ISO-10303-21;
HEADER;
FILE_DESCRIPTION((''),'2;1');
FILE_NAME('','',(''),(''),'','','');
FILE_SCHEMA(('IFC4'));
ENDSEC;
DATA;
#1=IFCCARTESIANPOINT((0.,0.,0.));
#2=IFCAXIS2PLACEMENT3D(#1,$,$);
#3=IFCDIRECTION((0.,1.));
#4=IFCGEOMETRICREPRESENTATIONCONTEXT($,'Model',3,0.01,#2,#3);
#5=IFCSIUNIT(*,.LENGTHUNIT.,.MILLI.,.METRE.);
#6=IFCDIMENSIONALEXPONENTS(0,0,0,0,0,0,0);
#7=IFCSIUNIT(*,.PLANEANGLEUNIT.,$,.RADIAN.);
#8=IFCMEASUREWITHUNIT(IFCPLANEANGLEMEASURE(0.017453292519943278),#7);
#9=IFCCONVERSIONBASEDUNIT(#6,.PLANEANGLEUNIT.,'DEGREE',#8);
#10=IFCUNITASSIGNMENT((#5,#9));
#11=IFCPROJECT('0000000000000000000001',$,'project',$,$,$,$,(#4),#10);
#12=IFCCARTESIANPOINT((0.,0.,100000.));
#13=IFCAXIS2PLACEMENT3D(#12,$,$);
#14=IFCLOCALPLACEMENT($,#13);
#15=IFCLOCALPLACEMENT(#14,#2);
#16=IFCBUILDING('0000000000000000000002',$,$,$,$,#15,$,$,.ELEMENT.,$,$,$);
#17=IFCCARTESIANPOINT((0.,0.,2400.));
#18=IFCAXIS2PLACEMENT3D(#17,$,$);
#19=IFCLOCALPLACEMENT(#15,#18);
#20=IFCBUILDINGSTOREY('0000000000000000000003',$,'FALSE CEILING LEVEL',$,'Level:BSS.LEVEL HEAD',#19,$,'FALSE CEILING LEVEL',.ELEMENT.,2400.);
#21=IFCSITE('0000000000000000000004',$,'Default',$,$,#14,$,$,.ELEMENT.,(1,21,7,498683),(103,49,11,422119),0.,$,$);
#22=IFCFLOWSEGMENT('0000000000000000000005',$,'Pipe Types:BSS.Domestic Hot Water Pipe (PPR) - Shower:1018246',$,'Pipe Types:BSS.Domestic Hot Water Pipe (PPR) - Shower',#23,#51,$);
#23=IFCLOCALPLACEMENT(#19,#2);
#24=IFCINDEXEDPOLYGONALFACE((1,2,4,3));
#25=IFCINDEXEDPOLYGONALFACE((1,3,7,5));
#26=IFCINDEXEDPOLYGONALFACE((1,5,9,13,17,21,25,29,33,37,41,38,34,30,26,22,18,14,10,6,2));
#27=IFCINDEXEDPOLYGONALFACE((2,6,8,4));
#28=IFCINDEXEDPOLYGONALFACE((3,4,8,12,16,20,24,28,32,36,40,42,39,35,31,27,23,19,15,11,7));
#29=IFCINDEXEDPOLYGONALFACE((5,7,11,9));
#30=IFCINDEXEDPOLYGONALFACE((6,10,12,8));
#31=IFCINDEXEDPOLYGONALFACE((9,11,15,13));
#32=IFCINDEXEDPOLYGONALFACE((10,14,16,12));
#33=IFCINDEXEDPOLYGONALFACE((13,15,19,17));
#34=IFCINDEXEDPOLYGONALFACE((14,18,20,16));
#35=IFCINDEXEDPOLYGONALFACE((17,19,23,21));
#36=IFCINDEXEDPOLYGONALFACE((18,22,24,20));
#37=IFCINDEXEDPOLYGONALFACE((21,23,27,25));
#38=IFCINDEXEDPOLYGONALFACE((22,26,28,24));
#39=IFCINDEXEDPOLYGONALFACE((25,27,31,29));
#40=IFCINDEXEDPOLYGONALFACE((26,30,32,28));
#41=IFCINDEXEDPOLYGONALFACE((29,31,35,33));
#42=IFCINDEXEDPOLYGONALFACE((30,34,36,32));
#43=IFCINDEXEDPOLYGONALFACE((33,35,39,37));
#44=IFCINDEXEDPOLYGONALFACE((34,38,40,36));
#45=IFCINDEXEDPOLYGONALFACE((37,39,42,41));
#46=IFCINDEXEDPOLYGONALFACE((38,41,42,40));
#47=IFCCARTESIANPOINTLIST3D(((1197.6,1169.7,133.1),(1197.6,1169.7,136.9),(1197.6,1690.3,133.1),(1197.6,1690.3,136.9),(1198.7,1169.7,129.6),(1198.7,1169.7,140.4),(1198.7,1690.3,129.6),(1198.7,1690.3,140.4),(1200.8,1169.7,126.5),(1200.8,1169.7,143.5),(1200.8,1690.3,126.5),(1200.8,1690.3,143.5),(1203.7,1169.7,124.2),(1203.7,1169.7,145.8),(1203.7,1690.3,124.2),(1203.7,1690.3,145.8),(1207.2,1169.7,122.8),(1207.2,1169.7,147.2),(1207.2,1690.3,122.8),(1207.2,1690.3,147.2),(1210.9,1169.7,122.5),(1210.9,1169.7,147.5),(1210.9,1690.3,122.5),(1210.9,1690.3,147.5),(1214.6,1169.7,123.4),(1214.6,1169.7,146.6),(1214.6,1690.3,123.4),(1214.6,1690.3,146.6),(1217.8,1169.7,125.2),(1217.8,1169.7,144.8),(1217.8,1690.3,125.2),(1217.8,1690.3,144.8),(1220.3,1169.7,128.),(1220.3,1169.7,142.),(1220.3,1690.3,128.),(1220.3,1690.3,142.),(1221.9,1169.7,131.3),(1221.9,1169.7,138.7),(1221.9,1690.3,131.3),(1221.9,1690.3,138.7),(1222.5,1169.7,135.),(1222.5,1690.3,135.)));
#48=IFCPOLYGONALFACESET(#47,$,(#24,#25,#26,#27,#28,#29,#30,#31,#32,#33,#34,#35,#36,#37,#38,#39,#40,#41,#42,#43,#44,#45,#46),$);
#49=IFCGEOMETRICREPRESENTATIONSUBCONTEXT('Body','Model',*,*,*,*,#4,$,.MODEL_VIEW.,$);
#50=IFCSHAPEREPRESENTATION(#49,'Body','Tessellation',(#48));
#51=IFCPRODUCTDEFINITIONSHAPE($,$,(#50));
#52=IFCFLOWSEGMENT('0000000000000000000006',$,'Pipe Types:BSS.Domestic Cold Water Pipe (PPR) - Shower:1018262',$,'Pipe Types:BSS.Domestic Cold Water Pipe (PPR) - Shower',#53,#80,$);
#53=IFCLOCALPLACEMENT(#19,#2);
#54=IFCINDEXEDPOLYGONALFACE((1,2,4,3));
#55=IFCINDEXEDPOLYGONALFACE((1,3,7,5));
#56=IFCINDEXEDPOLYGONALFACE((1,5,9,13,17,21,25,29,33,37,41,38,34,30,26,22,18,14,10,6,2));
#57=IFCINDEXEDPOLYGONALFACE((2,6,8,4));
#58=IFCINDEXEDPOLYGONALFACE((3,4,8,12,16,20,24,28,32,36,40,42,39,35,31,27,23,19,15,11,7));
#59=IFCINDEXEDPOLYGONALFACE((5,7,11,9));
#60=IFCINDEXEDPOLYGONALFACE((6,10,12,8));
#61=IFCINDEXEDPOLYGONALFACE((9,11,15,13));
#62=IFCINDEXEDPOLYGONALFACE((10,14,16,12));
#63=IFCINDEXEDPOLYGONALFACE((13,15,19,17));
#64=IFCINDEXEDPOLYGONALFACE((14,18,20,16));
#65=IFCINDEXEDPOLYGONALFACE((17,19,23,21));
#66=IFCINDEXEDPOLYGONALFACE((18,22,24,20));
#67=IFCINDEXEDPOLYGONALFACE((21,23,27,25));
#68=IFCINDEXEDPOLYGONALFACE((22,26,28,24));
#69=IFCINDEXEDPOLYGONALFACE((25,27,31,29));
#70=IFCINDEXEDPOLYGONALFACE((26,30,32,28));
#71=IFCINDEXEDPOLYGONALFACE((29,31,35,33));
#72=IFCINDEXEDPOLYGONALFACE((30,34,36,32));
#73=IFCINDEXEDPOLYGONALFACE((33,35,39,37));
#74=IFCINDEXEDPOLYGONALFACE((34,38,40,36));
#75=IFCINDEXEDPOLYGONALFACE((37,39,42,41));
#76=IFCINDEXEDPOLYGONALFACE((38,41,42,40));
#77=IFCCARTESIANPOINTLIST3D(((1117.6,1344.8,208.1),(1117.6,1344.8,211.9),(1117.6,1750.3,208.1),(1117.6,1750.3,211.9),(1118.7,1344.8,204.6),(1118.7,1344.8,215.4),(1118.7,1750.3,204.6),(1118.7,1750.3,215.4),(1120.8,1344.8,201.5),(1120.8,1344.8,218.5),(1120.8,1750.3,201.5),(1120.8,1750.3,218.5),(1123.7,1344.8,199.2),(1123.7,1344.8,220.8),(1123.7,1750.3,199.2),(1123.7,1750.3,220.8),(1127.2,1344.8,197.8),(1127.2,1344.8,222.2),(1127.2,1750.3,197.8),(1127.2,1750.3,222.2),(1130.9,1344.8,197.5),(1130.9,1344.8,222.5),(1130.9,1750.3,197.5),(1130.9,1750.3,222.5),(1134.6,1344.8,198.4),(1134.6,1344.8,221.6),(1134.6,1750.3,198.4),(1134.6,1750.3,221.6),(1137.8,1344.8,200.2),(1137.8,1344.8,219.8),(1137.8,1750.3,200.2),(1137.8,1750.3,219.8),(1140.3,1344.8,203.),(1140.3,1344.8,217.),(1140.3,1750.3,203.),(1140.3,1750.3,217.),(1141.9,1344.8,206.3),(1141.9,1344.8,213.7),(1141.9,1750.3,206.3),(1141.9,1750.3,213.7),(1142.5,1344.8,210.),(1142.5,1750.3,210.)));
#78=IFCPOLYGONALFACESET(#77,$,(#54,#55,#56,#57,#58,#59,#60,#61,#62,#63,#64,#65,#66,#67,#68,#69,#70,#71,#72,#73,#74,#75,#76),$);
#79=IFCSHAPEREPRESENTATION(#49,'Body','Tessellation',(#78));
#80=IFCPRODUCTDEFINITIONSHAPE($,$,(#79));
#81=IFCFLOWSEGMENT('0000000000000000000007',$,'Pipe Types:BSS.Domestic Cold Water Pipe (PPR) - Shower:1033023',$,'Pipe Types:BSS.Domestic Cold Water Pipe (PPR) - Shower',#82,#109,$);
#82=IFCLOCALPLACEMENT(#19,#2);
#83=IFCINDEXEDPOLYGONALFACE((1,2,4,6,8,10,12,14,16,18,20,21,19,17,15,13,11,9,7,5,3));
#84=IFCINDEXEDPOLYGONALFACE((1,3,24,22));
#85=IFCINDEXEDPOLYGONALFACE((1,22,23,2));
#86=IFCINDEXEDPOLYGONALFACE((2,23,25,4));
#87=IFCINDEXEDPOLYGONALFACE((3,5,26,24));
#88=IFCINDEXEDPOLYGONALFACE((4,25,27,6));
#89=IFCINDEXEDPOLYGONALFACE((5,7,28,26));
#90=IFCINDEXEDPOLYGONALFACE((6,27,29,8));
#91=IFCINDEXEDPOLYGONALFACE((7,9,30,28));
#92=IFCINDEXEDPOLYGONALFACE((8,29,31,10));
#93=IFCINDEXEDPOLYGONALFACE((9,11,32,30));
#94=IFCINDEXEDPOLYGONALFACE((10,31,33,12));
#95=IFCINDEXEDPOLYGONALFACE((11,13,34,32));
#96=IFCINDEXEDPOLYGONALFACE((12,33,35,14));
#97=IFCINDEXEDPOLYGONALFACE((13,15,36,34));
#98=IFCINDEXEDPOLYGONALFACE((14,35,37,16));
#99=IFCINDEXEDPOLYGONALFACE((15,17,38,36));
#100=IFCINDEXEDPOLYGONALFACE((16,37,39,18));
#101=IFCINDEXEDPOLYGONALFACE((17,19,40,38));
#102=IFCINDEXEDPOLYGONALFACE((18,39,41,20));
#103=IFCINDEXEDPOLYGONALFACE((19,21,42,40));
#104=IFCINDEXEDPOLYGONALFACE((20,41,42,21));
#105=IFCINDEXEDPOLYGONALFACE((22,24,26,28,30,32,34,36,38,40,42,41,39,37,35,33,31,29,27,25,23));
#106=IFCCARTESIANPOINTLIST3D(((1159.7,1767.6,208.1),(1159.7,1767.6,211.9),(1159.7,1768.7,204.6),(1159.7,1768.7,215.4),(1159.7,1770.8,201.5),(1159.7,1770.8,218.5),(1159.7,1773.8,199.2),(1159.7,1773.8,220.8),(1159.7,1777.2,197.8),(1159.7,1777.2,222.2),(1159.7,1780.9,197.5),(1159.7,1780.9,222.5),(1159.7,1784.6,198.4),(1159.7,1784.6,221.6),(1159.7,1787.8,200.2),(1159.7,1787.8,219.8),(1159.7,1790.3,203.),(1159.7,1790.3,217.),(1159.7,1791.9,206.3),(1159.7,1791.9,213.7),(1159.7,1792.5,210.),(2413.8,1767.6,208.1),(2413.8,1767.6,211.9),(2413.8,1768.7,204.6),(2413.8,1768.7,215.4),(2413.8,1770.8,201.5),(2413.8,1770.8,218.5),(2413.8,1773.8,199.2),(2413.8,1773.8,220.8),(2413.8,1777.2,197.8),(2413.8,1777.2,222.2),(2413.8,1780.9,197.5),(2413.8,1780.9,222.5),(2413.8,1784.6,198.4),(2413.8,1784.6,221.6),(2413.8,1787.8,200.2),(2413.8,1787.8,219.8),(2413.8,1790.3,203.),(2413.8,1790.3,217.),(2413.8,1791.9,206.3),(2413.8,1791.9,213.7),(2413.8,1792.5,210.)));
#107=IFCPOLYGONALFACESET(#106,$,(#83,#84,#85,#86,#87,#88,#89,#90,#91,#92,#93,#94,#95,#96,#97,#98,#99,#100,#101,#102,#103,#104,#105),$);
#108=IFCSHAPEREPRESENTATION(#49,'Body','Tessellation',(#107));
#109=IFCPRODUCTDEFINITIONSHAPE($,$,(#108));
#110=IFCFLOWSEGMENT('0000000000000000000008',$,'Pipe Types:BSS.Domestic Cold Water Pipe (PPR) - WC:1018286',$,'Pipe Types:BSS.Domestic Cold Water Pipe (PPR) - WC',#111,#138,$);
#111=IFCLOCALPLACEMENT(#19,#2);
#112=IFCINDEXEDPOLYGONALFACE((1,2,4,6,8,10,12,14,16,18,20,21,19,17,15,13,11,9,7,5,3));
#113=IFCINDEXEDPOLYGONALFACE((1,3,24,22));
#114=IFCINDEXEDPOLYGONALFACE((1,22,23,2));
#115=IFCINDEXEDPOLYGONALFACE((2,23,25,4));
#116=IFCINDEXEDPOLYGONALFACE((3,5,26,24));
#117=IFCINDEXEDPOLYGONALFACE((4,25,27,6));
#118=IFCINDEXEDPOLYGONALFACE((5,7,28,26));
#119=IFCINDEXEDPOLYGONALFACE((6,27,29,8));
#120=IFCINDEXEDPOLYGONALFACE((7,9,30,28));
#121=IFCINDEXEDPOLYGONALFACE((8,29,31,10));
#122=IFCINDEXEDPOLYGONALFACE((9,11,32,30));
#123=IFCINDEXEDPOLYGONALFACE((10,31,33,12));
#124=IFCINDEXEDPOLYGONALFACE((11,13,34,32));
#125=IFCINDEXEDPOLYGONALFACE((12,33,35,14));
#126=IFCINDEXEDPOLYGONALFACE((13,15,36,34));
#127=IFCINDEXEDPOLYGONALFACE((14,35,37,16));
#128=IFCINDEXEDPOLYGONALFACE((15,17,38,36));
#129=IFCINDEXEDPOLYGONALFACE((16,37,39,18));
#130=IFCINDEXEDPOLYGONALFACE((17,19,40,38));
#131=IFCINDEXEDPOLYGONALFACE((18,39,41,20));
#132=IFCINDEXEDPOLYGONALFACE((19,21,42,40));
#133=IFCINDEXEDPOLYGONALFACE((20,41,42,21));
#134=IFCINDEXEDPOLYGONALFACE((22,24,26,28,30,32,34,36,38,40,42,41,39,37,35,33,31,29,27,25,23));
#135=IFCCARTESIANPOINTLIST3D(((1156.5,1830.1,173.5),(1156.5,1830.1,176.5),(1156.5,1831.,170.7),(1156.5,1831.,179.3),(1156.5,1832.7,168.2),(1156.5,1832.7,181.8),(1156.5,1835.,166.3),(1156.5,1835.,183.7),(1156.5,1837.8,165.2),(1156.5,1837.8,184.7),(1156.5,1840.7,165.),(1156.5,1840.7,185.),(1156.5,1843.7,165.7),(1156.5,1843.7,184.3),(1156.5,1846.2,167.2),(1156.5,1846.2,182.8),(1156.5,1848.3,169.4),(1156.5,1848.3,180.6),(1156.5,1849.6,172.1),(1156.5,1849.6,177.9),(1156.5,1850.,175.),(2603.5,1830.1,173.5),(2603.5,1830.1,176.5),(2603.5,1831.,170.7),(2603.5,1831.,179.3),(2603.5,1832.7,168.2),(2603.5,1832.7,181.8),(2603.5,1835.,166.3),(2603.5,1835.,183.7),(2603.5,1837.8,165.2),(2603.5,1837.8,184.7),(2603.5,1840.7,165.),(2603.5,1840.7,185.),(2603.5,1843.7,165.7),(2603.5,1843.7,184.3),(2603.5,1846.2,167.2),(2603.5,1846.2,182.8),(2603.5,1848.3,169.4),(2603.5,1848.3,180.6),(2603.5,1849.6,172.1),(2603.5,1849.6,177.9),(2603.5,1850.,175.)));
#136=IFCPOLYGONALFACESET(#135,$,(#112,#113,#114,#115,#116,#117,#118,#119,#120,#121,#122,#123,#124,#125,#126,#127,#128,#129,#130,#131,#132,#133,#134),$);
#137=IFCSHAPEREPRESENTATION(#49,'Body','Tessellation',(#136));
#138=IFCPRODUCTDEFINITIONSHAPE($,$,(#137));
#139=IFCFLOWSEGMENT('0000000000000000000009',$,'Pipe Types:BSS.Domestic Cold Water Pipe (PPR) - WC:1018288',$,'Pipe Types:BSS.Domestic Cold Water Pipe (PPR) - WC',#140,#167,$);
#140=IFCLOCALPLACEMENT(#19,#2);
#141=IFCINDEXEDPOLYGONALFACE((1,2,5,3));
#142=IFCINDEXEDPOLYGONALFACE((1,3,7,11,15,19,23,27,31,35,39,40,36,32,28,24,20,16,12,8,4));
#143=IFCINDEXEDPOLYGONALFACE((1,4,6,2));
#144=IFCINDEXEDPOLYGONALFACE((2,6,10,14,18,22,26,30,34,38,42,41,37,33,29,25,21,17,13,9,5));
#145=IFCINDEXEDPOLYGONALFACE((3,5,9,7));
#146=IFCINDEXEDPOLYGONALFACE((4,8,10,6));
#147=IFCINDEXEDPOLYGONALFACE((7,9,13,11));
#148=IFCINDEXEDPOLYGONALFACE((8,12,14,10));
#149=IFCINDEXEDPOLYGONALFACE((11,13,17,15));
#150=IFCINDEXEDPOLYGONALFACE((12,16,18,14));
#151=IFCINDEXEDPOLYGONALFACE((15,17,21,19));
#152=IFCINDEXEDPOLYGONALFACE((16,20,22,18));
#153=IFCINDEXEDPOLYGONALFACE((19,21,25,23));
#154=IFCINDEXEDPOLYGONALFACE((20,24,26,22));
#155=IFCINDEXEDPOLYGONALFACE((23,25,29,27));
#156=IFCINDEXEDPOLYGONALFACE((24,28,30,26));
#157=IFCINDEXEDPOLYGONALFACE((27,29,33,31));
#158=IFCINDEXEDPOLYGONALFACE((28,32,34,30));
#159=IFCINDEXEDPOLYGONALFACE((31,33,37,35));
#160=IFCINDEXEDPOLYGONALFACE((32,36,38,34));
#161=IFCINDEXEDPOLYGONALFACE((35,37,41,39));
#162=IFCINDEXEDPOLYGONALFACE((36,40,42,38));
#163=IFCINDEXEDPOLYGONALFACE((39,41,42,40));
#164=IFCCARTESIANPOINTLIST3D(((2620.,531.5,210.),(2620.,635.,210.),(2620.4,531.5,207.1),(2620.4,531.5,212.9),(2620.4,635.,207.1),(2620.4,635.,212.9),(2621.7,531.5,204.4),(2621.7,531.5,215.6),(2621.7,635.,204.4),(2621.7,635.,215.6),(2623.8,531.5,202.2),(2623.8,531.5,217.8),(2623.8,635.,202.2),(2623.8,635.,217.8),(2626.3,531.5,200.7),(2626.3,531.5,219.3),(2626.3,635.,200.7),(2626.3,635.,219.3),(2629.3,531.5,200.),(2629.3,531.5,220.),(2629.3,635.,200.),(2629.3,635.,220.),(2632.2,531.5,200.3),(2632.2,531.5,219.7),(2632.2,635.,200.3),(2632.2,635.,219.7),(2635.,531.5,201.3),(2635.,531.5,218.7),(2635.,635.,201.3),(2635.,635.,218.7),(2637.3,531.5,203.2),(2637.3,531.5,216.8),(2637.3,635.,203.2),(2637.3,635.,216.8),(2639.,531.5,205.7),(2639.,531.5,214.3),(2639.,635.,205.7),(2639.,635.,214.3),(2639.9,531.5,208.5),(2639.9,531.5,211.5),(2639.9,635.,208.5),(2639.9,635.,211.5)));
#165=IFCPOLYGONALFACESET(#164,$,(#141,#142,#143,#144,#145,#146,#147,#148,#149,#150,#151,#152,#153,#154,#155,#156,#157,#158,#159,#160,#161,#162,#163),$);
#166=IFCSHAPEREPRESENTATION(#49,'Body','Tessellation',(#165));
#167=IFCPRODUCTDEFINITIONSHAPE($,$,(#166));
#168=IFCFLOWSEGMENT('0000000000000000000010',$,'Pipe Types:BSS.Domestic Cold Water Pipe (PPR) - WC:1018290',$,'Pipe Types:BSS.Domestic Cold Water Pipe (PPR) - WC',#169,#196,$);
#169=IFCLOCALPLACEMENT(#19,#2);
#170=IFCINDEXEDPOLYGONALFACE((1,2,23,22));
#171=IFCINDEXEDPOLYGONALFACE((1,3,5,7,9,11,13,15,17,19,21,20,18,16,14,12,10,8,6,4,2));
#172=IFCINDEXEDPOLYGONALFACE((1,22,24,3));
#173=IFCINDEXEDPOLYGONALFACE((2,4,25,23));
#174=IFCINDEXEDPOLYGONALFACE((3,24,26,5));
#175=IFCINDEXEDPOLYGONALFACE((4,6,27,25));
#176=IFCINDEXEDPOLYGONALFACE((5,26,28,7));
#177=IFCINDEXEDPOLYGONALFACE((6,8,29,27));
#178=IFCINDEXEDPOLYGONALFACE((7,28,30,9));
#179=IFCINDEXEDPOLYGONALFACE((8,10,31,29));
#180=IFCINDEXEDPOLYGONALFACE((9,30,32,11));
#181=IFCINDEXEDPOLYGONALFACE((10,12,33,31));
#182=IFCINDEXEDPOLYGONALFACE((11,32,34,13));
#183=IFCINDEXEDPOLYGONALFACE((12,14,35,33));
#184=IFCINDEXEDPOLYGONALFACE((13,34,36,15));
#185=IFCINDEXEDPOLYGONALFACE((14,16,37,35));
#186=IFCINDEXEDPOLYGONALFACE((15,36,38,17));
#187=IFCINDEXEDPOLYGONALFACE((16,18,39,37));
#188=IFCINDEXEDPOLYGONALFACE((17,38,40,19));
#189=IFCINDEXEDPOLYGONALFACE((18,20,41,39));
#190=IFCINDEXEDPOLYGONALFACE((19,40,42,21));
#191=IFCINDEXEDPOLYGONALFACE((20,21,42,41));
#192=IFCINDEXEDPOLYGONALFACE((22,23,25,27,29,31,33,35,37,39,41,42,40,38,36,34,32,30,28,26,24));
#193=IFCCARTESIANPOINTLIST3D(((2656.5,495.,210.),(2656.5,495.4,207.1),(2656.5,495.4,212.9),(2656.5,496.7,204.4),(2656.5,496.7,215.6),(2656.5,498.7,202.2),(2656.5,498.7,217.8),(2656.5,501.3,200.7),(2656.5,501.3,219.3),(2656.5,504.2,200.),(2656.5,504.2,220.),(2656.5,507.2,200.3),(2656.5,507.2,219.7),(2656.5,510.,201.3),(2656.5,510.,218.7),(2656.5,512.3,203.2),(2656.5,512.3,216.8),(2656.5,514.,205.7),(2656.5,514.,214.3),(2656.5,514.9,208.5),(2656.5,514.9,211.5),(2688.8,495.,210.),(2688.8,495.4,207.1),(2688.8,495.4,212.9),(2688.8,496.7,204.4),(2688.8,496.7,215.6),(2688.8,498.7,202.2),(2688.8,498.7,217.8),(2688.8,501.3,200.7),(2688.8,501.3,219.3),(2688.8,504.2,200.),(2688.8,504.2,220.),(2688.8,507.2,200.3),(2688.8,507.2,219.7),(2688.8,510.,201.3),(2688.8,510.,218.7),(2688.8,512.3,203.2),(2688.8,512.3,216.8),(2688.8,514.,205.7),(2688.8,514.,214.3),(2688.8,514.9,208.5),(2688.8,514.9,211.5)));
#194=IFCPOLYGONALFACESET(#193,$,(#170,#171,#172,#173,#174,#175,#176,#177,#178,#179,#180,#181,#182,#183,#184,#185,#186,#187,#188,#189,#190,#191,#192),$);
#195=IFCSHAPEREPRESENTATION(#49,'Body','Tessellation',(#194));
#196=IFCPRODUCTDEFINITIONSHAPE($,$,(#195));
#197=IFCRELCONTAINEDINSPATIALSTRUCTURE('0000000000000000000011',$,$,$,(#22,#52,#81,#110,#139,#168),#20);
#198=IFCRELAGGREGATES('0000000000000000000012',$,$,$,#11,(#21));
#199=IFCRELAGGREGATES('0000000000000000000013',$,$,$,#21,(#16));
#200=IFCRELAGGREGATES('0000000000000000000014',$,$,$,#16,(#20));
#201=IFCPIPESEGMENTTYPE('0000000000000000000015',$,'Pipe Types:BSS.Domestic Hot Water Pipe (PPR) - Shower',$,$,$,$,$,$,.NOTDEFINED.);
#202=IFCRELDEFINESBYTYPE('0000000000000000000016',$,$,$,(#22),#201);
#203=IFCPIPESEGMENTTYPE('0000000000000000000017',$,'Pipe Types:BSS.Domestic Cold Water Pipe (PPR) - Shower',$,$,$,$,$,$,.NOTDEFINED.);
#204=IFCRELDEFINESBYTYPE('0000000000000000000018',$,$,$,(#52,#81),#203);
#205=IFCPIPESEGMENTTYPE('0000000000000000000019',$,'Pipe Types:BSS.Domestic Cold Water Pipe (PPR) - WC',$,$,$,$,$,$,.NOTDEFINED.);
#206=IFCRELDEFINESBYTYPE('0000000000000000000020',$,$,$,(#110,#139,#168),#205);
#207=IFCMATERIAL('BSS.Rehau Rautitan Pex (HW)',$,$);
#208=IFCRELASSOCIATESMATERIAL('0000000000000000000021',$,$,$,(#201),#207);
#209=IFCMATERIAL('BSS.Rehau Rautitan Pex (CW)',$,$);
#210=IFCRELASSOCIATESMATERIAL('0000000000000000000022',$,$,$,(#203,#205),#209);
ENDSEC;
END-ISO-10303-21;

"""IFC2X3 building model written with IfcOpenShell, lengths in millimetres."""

from ifc_helpers import new_model, entity, si_unit, converted_unit, direction, frame, frame_2d, origin, origin_2d_with_axis, place, context, subcontext, project, spatial, circle, extrude, material, type_object, element, save


model = new_model("IFC2X3")

# Units and contexts
model_context = context("Model", 3, precision=0.01, world=origin(), true_north=direction((0.0, 1.0)))
body_context = subcontext(model_context, "Body", "Model", "MODEL_VIEW")
ifc_project = project(units=[si_unit("LENGTHUNIT", "METRE", prefix="MILLI"), converted_unit("PLANEANGLEUNIT", "DEGREE", entity("IfcPlaneAngleMeasure", 0.017453292519943278), si_unit("PLANEANGLEUNIT", "RADIAN"), dimensions=[0, 0, 0, 0, 0, 0, 0])], contexts=[model_context])

# Site, building, storey
site_placement = place(None, frame((0.0, 0.0, 100000.0)))
site = spatial("IfcSite", under=ifc_project, at=site_placement, Name="Default", CompositionType="ELEMENT", RefLatitude=(1, 21, 7, 498683), RefLongitude=(103, 49, 11, 422119), RefElevation=0.0)
building_placement = place(site_placement, origin())
building = spatial("IfcBuilding", under=site, at=building_placement, CompositionType="ELEMENT")
storey_placement = place(building_placement, frame((0.0, 0.0, 2400.0)))
storey = spatial("IfcBuildingStorey", under=building, at=storey_placement, Name="FALSE CEILING LEVEL", ObjectType="Level:BSS.LEVEL HEAD", LongName="FALSE CEILING LEVEL", CompositionType="ELEMENT", Elevation=2400.0)

# Flow segments
ifc_material_1 = material(Name="BSS.Rehau Rautitan Pex (HW)")
pipe_segment_type_1 = type_object("IfcPipeSegmentType", Name="Pipe Types:BSS.Domestic Hot Water Pipe (PPR) - Shower", PredefinedType="NOTDEFINED", material=ifc_material_1)
flow_segment_1_placement = place(storey_placement, origin())
element("IfcFlowSegment", 1, at=flow_segment_1_placement, inside=storey, type_object=pipe_segment_type_1, Name="Pipe Types:BSS.Domestic Hot Water Pipe (PPR) - Shower:1018246", ObjectType="Pipe Types:BSS.Domestic Hot Water Pipe (PPR) - Shower", context=body_context, shape_type="SweptSolid", body=[
    extrude(circle(Radius=12.5, at=origin_2d_with_axis()), frame((1210.0, 1169.7, 135.0), z_axis=(0.0, 1.0, 0.0), x_axis=(1.0, 0.0, 0.0)), (0.0, 0.0, 1.0), 520.6),
])
ifc_material_2 = material(Name="BSS.Rehau Rautitan Pex (CW)")
pipe_segment_type_2 = type_object("IfcPipeSegmentType", Name="Pipe Types:BSS.Domestic Cold Water Pipe (PPR) - Shower", PredefinedType="NOTDEFINED", material=ifc_material_2)
flow_segment_2_placement = place(storey_placement, origin())
element("IfcFlowSegment", 2, at=flow_segment_2_placement, inside=storey, type_object=pipe_segment_type_2, Name="Pipe Types:BSS.Domestic Cold Water Pipe (PPR) - Shower:1018262", ObjectType="Pipe Types:BSS.Domestic Cold Water Pipe (PPR) - Shower", context=body_context, shape_type="SweptSolid", body=[
    extrude(circle(Radius=12.5, at=frame_2d((0.0, 0.0), x_axis=(1.0, 0.0))), frame((1130.0, 1344.8, 210.0), z_axis=(0.000001, 1.0, 0.0), x_axis=(1.0, -0.000001, 0.0)), (0.0, 0.0, 1.0), 405.5),
])
flow_segment_3_placement = place(storey_placement, origin())
element("IfcFlowSegment", 3, at=flow_segment_3_placement, inside=storey, type_object=pipe_segment_type_2, Name="Pipe Types:BSS.Domestic Cold Water Pipe (PPR) - Shower:1033023", ObjectType="Pipe Types:BSS.Domestic Cold Water Pipe (PPR) - Shower", context=body_context, shape_type="SweptSolid", body=[
    extrude(circle(Radius=12.5, at=frame_2d((0.0, 0.0), x_axis=(1.0, 0.0))), frame((1159.7, 1780.0, 210.0), z_axis=(1.0, 0.0, 0.0), x_axis=(0.0, 1.0, 0.0)), (0.0, 0.0, 1.0), 1254.1),
])
pipe_segment_type_3 = type_object("IfcPipeSegmentType", Name="Pipe Types:BSS.Domestic Cold Water Pipe (PPR) - WC", PredefinedType="NOTDEFINED", material=ifc_material_2)
flow_segment_4_placement = place(storey_placement, origin())
element("IfcFlowSegment", 4, at=flow_segment_4_placement, inside=storey, type_object=pipe_segment_type_3, Name="Pipe Types:BSS.Domestic Cold Water Pipe (PPR) - WC:1018286", ObjectType="Pipe Types:BSS.Domestic Cold Water Pipe (PPR) - WC", context=body_context, shape_type="SweptSolid", body=[
    extrude(circle(Radius=10.0, at=origin_2d_with_axis()), frame((1156.5, 1840.0, 175.0), z_axis=(1.0, 0.0, 0.0), x_axis=(0.0, 1.0, 0.0)), (0.0, 0.0, 1.0), 1447.0),
])
flow_segment_5_placement = place(storey_placement, origin())
element("IfcFlowSegment", 5, at=flow_segment_5_placement, inside=storey, type_object=pipe_segment_type_3, Name="Pipe Types:BSS.Domestic Cold Water Pipe (PPR) - WC:1018288", ObjectType="Pipe Types:BSS.Domestic Cold Water Pipe (PPR) - WC", context=body_context, shape_type="SweptSolid", body=[
    extrude(circle(Radius=10.0, at=frame_2d((0.0, 0.0), x_axis=(1.0, 0.0))), frame((2630.0, 531.5, 210.0), z_axis=(0.0, 1.0, 0.0), x_axis=(-1.0, 0.0, 0.0)), (0.0, 0.0, 1.0), 103.5),
])
flow_segment_6_placement = place(storey_placement, origin())
element("IfcFlowSegment", 6, at=flow_segment_6_placement, inside=storey, type_object=pipe_segment_type_3, Name="Pipe Types:BSS.Domestic Cold Water Pipe (PPR) - WC:1018290", ObjectType="Pipe Types:BSS.Domestic Cold Water Pipe (PPR) - WC", context=body_context, shape_type="SweptSolid", body=[
    extrude(circle(Radius=10.0, at=origin_2d_with_axis()), frame((2656.5, 505.0, 210.0), z_axis=(1.0, 0.0, 0.0), x_axis=(0.0, -1.0, 0.0)), (0.0, 0.0, 1.0), 32.3),
])

save(model, "model.ifc")
